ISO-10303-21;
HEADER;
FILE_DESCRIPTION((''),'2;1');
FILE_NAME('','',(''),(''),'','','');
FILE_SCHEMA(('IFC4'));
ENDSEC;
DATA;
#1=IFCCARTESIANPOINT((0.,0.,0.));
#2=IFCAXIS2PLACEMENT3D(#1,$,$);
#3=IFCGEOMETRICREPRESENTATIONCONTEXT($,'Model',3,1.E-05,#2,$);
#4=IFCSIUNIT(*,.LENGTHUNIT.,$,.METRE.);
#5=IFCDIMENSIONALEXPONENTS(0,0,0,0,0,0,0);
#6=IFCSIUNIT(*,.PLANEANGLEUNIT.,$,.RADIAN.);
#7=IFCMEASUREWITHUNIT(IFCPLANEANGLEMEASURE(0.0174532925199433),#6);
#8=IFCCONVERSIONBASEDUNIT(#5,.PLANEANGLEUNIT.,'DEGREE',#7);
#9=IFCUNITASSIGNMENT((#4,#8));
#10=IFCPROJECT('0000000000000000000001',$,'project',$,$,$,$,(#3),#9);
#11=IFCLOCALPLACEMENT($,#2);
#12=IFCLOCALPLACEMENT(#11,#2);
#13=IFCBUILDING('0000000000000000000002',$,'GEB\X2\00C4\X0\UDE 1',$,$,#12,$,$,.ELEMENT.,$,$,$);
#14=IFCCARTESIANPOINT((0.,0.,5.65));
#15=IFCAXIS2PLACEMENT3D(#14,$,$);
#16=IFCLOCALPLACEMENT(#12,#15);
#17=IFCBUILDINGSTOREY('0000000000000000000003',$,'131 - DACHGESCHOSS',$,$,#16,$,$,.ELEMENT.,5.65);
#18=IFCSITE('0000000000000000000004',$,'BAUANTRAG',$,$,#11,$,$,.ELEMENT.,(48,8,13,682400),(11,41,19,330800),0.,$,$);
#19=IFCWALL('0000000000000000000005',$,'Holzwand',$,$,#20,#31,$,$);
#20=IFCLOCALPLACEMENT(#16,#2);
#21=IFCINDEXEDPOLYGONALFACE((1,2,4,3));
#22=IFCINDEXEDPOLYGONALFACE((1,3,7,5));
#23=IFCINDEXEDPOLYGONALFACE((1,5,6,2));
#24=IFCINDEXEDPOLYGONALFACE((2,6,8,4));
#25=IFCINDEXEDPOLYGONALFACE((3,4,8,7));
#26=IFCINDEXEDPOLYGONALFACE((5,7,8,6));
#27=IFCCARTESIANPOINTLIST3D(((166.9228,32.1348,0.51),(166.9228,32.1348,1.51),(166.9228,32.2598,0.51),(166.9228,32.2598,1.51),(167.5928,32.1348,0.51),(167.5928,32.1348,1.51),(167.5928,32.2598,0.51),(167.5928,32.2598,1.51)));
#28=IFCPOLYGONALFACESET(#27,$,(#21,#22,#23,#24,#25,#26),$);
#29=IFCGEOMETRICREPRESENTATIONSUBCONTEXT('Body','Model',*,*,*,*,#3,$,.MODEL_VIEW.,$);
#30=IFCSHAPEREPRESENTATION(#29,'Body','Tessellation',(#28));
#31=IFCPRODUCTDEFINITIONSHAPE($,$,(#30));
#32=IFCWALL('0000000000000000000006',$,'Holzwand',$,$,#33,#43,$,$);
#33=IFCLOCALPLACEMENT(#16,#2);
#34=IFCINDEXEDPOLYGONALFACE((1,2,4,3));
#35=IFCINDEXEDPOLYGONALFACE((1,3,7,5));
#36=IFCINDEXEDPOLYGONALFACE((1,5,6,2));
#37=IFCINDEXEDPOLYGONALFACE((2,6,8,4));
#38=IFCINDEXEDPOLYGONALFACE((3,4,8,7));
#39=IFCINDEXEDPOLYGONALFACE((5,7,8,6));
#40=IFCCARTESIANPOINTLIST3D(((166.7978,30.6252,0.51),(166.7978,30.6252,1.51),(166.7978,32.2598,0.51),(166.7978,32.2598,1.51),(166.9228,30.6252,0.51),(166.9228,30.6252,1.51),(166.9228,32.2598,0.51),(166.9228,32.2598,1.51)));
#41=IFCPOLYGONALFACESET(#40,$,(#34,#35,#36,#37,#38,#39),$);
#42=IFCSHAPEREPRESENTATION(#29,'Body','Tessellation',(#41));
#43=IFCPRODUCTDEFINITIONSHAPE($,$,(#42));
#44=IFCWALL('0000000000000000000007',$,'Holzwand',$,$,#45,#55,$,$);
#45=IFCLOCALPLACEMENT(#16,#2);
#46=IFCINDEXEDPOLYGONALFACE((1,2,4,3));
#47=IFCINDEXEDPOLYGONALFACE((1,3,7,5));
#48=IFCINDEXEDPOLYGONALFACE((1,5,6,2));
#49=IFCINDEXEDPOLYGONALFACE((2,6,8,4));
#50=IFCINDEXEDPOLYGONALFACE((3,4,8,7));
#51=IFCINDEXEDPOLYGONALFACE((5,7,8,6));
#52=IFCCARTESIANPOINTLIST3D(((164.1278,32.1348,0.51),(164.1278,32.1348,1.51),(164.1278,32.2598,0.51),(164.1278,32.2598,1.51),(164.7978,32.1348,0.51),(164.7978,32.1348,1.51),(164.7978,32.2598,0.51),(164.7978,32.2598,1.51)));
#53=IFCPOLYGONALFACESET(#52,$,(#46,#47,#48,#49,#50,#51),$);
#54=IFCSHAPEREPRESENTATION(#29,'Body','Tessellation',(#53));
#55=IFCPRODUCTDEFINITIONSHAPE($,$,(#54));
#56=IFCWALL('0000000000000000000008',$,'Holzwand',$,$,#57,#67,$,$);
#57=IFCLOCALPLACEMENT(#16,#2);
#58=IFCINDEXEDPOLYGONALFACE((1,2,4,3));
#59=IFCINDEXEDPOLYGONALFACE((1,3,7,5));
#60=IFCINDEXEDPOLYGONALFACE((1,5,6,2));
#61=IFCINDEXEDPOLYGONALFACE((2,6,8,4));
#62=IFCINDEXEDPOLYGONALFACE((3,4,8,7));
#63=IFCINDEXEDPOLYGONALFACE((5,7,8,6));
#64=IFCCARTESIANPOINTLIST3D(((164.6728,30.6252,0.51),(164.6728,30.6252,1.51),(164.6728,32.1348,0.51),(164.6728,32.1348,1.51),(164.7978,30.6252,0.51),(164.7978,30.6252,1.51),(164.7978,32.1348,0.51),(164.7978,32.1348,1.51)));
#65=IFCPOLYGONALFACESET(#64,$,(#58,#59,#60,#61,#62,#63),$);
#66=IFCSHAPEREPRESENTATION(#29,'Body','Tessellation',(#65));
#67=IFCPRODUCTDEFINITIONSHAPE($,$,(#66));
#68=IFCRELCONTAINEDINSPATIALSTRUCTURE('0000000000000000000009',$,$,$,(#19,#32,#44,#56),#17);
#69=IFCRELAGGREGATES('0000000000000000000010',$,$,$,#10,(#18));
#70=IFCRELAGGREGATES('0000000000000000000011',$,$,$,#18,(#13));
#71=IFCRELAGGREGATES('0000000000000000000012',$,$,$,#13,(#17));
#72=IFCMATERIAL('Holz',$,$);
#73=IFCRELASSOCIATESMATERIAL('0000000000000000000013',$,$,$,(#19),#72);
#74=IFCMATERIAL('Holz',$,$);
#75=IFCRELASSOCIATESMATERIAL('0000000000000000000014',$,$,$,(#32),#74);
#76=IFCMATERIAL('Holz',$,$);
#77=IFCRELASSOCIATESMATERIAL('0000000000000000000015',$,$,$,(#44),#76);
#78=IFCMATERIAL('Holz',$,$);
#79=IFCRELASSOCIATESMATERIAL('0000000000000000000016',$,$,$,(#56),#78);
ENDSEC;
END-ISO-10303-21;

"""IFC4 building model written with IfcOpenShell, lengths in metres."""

from ifc_helpers import new_model, entity, si_unit, converted_unit, frame, origin, place, context, subcontext, project, spatial, indexed_curve, outline, extrude, material, element, save


model = new_model("IFC4")

# Units and contexts
model_context = context("Model", 3, precision=1e-05, world=origin())
body_context = subcontext(model_context, "Body", "Model", "MODEL_VIEW")
ifc_project = project(units=[si_unit("LENGTHUNIT", "METRE"), converted_unit("PLANEANGLEUNIT", "DEGREE", entity("IfcPlaneAngleMeasure", 0.0174532925199433), si_unit("PLANEANGLEUNIT", "RADIAN"), dimensions=[0, 0, 0, 0, 0, 0, 0])], contexts=[model_context])

# Site, building, storey
site_placement = place(None, origin())
site = spatial("IfcSite", under=ifc_project, at=site_placement, Name="BAUANTRAG", CompositionType="ELEMENT", RefLatitude=(48, 8, 13, 682400), RefLongitude=(11, 41, 19, 330800), RefElevation=0.0)
building_placement = place(site_placement, origin())
building = spatial("IfcBuilding", under=site, at=building_placement, Name="GEBÄUDE 1", CompositionType="ELEMENT")
storey_placement = place(building_placement, frame((0.0, 0.0, 5.65)))
storey = spatial("IfcBuildingStorey", under=building, at=storey_placement, Name="131 - DACHGESCHOSS", CompositionType="ELEMENT", Elevation=5.65)

# Walls
ifc_material_1 = material(Name="Holz")
wall_1_placement = place(storey_placement, frame((167.5928, 32.2598, 0.51), z_axis=(0.0, 0.0, 1.0), x_axis=(-1.0, 0.0, 0.0)))
element("IfcWall", 1, at=wall_1_placement, inside=storey, material=ifc_material_1, Name="Holzwand", context=body_context, shape_type="SweptSolid", body=[
    extrude(outline(indexed_curve([(-0.67, -0.125), (0.0, -0.125), (0.0, 0.0), (-0.67, 0.0), (-0.67, -0.125)], self_intersect=False)), frame((0.67, 0.125, 0.0), z_axis=(0.0, 0.0, 1.0), x_axis=(1.0, 0.0, 0.0)), (0.0, 0.0, 1.0), 1.0),
])
ifc_material_2 = material(Name="Holz")
wall_2_placement = place(storey_placement, frame((166.7978, 32.2598, 0.51), z_axis=(0.0, 0.0, 1.0), x_axis=(0.0, -1.0, 0.0)))
element("IfcWall", 2, at=wall_2_placement, inside=storey, material=ifc_material_2, Name="Holzwand", context=body_context, shape_type="SweptSolid", body=[
    extrude(outline(indexed_curve([(-1.6346, 0.0), (0.0, 0.0), (0.0, 0.125), (-1.6346, 0.125), (-1.6346, 0.0)], self_intersect=False)), frame((1.6346, 0.0, 0.0), z_axis=(0.0, 0.0, 1.0), x_axis=(1.0, 0.0, 0.0)), (0.0, 0.0, 1.0), 1.0),
])
ifc_material_3 = material(Name="Holz")
wall_3_placement = place(storey_placement, frame((164.7978, 32.2598, 0.51), z_axis=(0.0, 0.0, 1.0), x_axis=(-1.0, 0.0, 0.0)))
element("IfcWall", 3, at=wall_3_placement, inside=storey, material=ifc_material_3, Name="Holzwand", context=body_context, shape_type="SweptSolid", body=[
    extrude(outline(indexed_curve([(-0.67, -0.125), (0.0, -0.125), (0.0, 0.0), (-0.67, 0.0), (-0.67, -0.125)], self_intersect=False)), frame((0.67, 0.125, 0.0), z_axis=(0.0, 0.0, 1.0), x_axis=(1.0, 0.0, 0.0)), (0.0, 0.0, 1.0), 1.0),
])
ifc_material_4 = material(Name="Holz")
wall_4_placement = place(storey_placement, frame((164.7978, 30.6252, 0.51), z_axis=(0.0, 0.0, 1.0), x_axis=(0.0, 1.0, 0.0)))
element("IfcWall", 4, at=wall_4_placement, inside=storey, material=ifc_material_4, Name="Holzwand", context=body_context, shape_type="SweptSolid", body=[
    extrude(outline(indexed_curve([(0.0, -0.125), (1.5096, -0.125), (1.5096, 0.0), (0.0, 0.0), (0.0, -0.125)], self_intersect=False)), frame((0.0, 0.125, 0.0), z_axis=(0.0, 0.0, 1.0), x_axis=(1.0, 0.0, 0.0)), (0.0, 0.0, 1.0), 1.0),
])

save(model, "model.ifc")
